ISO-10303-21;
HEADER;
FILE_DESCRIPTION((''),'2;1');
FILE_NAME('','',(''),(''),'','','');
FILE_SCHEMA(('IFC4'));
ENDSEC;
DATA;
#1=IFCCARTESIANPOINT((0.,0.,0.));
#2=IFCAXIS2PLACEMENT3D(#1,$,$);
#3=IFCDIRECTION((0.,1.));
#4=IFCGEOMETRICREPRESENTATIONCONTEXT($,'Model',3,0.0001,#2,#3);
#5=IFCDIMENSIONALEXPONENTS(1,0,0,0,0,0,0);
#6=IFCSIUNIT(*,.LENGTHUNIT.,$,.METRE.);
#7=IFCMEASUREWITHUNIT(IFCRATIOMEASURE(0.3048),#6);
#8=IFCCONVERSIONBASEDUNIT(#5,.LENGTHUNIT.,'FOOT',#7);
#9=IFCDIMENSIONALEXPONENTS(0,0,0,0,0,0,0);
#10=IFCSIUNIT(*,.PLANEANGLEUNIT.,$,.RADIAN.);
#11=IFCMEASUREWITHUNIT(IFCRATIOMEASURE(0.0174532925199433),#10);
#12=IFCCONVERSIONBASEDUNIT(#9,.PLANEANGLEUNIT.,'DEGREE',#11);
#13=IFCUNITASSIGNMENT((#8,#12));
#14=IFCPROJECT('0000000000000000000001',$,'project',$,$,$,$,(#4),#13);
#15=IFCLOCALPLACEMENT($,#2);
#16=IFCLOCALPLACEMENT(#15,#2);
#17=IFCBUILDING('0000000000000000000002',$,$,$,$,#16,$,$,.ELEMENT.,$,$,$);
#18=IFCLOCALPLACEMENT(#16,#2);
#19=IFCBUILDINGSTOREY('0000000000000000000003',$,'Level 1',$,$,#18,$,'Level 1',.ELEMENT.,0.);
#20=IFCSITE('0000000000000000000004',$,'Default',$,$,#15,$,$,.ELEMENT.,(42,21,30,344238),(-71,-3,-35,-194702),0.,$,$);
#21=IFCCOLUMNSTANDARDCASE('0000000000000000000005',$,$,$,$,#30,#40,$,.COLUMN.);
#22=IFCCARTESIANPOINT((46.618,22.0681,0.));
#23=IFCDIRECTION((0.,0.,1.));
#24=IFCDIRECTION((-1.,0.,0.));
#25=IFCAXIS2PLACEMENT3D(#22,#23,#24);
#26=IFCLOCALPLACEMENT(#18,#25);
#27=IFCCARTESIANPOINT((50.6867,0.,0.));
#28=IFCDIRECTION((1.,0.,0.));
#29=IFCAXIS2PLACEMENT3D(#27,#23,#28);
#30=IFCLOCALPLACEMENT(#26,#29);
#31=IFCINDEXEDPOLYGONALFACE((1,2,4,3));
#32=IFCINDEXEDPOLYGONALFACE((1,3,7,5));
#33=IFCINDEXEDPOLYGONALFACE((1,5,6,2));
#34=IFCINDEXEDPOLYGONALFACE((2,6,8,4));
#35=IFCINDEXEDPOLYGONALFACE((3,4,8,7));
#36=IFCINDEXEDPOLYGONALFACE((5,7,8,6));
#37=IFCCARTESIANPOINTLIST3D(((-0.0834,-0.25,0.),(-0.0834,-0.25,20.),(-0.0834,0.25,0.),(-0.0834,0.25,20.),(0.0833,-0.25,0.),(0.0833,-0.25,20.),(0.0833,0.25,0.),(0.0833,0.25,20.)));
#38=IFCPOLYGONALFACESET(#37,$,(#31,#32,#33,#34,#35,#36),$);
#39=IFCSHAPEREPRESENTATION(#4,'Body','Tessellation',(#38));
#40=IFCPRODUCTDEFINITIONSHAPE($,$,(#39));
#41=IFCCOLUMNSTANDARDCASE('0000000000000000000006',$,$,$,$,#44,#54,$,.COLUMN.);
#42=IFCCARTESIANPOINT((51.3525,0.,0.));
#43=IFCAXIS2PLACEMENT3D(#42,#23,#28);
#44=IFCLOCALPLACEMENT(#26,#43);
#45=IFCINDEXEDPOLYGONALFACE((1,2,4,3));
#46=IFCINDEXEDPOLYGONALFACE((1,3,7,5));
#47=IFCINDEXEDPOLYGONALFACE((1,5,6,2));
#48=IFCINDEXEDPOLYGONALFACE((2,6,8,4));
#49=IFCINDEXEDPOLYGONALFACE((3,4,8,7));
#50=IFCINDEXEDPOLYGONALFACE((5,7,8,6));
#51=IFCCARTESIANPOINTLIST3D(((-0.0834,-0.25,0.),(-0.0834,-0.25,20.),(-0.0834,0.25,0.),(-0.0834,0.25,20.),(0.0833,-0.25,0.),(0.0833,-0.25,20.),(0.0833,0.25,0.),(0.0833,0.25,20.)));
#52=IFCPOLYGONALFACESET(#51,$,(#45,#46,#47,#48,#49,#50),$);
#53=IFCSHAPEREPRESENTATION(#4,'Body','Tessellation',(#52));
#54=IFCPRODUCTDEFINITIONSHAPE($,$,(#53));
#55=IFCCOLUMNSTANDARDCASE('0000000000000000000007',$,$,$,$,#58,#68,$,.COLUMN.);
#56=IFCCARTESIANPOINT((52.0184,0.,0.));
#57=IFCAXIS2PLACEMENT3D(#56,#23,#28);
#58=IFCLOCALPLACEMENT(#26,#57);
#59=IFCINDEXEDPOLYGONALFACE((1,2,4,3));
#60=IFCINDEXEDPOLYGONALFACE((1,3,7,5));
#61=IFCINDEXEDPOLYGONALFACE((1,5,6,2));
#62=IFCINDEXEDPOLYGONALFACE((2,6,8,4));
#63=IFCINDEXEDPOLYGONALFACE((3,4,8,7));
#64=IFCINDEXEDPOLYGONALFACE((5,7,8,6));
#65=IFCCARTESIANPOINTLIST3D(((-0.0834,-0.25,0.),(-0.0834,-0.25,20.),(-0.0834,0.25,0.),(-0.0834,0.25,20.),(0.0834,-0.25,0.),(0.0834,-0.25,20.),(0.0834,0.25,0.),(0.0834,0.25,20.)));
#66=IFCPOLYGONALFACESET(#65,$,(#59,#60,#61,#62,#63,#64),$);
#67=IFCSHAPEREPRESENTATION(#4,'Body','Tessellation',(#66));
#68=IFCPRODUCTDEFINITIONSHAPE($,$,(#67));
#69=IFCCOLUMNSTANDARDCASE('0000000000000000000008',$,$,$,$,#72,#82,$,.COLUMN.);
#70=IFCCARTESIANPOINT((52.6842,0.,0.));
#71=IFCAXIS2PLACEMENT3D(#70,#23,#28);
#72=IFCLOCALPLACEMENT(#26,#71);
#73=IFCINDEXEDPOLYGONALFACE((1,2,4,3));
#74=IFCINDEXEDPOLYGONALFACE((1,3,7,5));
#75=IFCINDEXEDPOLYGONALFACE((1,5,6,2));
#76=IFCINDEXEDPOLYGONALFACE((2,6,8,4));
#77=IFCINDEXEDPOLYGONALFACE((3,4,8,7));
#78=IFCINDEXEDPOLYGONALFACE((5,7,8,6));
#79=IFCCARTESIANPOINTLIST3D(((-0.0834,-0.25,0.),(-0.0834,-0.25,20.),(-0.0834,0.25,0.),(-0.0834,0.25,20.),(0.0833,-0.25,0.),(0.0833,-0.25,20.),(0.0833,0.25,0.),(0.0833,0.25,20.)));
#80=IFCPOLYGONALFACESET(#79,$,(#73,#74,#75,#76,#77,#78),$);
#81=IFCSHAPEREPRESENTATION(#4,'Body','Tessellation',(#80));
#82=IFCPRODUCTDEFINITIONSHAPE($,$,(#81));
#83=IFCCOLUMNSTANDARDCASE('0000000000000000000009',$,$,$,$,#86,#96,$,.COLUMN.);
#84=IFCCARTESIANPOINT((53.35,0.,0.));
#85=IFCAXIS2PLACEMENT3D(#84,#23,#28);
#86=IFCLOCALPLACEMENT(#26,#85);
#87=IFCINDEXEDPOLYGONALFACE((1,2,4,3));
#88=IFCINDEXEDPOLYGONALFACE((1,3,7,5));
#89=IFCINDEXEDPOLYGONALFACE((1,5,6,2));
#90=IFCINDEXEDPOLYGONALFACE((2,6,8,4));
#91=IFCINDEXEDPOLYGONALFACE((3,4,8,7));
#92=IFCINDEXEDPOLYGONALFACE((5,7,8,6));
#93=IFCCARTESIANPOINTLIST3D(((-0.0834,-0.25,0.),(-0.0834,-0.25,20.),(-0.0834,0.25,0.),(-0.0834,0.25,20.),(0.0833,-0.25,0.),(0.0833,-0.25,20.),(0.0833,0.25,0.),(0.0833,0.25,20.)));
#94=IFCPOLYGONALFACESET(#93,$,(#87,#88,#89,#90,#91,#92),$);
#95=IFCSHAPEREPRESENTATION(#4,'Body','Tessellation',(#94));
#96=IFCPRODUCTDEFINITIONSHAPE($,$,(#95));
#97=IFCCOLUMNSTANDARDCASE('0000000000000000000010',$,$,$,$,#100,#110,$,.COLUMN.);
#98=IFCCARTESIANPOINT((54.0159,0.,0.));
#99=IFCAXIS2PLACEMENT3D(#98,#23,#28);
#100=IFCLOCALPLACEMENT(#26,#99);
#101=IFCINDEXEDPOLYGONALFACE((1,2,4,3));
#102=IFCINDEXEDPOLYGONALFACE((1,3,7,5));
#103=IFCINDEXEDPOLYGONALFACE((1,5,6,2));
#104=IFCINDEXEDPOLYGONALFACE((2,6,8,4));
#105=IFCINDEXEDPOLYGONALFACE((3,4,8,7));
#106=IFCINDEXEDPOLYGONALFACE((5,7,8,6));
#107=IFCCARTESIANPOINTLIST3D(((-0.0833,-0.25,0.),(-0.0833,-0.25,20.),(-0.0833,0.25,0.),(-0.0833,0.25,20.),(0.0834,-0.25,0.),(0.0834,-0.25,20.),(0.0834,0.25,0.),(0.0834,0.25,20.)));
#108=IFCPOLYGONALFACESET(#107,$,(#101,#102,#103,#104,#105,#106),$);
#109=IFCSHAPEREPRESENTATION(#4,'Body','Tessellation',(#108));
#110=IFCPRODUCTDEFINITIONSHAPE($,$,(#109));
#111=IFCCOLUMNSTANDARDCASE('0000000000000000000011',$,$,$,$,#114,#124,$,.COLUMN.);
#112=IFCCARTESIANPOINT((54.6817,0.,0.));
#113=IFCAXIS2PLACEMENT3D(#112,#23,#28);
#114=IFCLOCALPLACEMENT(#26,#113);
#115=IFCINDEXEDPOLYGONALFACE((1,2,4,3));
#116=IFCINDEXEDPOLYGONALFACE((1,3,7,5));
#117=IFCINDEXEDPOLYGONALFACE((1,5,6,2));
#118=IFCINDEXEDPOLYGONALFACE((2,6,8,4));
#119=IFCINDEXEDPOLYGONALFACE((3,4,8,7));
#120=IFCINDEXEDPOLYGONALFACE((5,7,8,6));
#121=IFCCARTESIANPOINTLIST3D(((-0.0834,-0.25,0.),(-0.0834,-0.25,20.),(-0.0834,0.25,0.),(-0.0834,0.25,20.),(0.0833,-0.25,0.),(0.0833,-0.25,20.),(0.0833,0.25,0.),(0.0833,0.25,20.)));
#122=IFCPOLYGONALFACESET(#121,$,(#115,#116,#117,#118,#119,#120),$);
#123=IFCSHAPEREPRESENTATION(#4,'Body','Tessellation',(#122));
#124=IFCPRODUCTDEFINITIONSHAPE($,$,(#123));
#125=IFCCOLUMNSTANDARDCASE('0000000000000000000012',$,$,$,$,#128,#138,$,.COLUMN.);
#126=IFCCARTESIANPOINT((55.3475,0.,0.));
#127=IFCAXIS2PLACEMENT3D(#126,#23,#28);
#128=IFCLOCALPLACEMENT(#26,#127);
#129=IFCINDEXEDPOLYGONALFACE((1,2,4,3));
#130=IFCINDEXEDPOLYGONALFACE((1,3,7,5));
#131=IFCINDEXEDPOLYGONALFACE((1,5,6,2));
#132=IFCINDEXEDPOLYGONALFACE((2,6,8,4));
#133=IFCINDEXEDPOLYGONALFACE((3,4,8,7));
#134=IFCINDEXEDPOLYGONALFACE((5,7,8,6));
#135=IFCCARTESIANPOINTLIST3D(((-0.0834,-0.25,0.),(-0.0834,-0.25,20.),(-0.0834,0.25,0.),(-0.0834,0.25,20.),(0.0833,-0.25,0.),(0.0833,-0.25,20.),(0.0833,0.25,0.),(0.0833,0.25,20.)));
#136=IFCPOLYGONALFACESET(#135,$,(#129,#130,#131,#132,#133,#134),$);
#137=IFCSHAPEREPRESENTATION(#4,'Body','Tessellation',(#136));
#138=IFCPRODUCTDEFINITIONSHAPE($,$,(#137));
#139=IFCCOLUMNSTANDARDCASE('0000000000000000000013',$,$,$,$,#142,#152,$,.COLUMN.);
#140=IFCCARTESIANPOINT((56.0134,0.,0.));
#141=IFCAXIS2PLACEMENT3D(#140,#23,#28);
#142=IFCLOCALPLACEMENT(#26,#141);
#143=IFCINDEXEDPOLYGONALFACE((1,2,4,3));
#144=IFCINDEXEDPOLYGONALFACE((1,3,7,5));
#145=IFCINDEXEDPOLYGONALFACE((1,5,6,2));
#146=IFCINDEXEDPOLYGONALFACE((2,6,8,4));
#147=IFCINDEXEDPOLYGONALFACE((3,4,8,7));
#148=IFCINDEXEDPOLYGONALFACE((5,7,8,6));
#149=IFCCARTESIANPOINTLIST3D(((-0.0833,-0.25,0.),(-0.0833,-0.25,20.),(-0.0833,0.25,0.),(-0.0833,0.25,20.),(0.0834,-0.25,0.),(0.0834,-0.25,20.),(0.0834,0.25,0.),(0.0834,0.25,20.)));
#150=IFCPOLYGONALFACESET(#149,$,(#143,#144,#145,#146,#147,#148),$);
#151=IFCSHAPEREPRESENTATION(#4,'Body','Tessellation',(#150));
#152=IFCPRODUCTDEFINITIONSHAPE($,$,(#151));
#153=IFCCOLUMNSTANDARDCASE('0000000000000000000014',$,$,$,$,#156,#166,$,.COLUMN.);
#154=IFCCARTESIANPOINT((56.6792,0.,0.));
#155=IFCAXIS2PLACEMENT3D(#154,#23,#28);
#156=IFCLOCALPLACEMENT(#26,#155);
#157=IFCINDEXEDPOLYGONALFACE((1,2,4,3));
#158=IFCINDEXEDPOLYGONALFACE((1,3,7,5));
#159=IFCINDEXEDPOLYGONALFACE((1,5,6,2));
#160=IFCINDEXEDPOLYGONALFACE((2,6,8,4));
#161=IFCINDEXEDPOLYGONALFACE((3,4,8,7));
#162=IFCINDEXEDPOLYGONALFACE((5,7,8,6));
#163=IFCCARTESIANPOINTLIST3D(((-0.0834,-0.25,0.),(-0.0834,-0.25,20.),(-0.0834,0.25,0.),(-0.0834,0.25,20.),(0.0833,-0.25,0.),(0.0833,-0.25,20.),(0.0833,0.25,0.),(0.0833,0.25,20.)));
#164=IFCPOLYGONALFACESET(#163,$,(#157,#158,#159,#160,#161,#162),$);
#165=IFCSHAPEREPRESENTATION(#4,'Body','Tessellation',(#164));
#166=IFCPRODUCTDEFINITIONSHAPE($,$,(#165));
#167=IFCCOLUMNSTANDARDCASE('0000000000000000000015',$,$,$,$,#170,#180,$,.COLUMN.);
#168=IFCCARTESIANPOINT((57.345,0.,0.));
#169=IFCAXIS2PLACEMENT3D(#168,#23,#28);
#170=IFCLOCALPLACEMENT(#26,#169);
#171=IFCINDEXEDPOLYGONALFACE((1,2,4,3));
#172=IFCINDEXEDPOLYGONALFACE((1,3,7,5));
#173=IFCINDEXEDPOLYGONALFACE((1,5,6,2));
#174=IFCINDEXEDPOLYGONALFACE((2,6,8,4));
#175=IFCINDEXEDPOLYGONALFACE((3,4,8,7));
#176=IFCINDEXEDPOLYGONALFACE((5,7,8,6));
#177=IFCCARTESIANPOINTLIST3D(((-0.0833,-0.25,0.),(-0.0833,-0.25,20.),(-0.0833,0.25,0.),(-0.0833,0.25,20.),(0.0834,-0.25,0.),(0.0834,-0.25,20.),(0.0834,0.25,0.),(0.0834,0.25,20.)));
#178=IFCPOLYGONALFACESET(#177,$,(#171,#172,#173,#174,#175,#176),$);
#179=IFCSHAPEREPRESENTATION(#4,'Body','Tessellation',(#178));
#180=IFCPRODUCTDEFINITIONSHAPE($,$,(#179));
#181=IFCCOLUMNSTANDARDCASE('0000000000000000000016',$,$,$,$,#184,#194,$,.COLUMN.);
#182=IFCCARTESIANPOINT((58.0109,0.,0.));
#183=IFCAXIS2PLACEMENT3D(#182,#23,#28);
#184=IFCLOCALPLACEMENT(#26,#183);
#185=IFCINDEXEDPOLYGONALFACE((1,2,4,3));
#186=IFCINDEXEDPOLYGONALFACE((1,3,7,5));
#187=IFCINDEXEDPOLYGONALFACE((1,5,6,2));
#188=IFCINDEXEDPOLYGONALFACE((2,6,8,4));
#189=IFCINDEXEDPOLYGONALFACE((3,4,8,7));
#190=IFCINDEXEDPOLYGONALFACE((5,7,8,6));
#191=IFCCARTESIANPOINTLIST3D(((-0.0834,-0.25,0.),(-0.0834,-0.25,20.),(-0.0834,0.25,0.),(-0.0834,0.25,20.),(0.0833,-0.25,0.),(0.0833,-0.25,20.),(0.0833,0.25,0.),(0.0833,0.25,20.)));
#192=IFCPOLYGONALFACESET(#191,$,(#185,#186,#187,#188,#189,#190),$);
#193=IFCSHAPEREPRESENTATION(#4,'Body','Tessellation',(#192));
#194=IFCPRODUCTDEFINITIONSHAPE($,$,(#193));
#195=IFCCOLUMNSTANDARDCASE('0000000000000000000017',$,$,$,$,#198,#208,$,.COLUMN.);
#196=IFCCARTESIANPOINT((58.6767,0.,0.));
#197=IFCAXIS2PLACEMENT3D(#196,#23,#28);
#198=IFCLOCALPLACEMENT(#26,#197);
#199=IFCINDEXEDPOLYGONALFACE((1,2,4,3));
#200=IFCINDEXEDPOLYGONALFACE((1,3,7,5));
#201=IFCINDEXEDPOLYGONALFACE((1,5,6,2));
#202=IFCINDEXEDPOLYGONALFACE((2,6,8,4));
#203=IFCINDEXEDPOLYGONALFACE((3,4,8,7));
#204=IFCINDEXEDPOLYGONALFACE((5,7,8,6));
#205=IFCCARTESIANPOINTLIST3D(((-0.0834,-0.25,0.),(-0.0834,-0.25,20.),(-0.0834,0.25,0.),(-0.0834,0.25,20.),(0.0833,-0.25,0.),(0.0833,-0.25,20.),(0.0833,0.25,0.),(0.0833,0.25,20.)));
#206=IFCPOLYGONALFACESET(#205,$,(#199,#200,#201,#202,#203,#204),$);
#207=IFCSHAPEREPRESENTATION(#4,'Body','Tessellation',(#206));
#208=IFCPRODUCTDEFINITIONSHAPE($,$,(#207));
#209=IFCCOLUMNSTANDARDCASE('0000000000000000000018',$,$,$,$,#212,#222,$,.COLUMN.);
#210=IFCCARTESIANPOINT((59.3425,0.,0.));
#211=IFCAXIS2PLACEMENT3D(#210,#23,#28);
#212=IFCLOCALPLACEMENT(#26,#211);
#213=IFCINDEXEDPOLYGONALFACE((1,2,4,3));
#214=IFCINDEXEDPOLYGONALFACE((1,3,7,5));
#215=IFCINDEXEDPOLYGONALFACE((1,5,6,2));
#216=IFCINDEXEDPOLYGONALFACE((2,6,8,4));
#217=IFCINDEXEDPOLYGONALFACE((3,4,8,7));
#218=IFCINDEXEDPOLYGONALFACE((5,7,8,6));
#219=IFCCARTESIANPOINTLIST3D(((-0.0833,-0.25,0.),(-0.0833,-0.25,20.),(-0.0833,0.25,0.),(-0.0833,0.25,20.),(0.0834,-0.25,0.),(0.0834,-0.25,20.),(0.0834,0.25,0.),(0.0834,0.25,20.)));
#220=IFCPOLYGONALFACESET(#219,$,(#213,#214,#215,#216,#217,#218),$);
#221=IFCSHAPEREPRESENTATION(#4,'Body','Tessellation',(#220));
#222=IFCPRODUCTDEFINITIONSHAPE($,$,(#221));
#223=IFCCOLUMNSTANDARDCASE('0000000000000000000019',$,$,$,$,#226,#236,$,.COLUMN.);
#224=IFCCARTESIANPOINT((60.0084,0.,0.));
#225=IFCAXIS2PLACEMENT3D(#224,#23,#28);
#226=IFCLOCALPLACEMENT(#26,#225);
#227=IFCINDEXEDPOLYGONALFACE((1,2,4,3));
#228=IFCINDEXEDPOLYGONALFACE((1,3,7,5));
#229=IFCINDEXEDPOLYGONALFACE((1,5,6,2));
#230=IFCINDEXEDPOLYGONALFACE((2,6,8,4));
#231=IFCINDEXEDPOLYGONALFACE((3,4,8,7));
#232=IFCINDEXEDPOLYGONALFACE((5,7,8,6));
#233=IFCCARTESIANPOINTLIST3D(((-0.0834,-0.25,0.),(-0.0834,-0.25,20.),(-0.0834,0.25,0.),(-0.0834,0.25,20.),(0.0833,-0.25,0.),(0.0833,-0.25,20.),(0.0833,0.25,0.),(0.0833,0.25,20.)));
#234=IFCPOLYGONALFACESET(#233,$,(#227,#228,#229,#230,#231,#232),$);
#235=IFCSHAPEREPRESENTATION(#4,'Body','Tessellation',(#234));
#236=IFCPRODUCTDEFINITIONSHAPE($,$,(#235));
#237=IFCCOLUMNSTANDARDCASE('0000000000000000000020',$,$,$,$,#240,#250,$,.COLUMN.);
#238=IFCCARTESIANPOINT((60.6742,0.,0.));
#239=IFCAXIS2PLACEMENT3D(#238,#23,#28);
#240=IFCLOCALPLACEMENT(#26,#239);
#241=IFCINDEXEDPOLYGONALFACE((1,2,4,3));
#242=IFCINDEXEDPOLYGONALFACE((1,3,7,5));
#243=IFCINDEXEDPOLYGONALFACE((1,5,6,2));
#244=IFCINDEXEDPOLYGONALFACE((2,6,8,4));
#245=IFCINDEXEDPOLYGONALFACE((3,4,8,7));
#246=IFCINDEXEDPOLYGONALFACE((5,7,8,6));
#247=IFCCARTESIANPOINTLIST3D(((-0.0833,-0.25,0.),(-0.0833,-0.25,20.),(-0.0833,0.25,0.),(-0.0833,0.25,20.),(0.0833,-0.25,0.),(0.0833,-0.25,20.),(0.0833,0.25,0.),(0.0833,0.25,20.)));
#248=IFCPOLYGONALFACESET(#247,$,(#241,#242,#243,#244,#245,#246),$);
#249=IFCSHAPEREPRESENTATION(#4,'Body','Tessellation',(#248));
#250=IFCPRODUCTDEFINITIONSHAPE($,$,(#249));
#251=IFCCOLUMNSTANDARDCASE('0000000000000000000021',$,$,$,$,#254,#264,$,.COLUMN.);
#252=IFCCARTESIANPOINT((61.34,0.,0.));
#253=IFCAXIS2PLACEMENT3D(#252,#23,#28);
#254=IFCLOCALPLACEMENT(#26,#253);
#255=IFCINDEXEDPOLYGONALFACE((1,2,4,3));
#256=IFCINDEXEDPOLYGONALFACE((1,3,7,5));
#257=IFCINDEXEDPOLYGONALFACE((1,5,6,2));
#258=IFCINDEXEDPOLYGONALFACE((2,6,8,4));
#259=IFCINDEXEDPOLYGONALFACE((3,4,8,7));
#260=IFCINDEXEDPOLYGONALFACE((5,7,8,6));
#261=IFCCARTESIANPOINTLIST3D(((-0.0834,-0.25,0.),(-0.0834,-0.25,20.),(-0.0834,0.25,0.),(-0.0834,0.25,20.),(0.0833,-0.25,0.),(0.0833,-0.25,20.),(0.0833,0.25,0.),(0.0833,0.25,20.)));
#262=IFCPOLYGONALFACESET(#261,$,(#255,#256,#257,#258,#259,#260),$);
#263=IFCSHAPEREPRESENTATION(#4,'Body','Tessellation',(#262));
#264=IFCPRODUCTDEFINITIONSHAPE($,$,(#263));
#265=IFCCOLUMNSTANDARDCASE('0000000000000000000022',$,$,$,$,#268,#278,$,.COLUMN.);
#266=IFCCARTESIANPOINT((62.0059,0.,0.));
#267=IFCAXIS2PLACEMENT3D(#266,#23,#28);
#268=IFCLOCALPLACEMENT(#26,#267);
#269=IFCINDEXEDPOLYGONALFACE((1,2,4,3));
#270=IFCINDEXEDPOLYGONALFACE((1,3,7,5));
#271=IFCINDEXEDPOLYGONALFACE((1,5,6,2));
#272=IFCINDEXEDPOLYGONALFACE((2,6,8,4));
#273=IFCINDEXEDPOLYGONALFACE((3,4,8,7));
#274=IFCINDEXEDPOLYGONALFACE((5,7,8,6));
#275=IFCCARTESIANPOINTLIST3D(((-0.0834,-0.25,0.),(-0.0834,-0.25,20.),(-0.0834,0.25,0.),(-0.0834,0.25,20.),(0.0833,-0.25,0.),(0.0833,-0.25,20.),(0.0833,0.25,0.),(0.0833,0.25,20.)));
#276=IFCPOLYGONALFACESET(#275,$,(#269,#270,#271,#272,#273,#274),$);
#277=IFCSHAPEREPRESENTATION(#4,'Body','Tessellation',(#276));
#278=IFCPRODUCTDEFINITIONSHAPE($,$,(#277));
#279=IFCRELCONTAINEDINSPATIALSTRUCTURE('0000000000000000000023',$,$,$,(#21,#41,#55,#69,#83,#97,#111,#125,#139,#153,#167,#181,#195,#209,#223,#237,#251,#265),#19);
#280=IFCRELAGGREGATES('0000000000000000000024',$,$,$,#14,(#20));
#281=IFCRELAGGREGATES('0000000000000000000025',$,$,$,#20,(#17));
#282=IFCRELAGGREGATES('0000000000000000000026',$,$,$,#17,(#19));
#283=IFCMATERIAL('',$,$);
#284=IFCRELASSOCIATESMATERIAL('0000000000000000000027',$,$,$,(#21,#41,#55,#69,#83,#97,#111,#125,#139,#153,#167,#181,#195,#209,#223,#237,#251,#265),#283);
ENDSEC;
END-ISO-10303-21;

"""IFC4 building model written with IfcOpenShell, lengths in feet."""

from ifc_helpers import new_model, entity, si_unit, converted_unit, direction, frame, origin, place, context, project, spatial, rectangle, extrude, material, element, save


model = new_model("IFC4")

# Units and contexts
model_context = context("Model", 3, precision=0.0001, world=origin(), true_north=direction((0.0, 1.0)))
ifc_project = project(units=[converted_unit("LENGTHUNIT", "FOOT", entity("IfcRatioMeasure", 0.3048), si_unit("LENGTHUNIT", "METRE"), dimensions=[1, 0, 0, 0, 0, 0, 0]), converted_unit("PLANEANGLEUNIT", "DEGREE", entity("IfcRatioMeasure", 0.0174532925199433), si_unit("PLANEANGLEUNIT", "RADIAN"), dimensions=[0, 0, 0, 0, 0, 0, 0])], contexts=[model_context])

# Site, building, storey
site_placement = place(None, origin())
site = spatial("IfcSite", under=ifc_project, at=site_placement, Name="Default", CompositionType="ELEMENT", RefLatitude=(42, 21, 30, 344238), RefLongitude=(-71, -3, -35, -194702), RefElevation=0.0)
building_placement = place(site_placement, origin())
building = spatial("IfcBuilding", under=site, at=building_placement, CompositionType="ELEMENT")
storey_placement = place(building_placement, origin())
storey = spatial("IfcBuildingStorey", under=building, at=storey_placement, Name="Level 1", LongName="Level 1", CompositionType="ELEMENT", Elevation=0.0)

# Columns
ifc_material_1 = material(Name="")
placement = place(storey_placement, frame((46.618, 22.0681, 0.0), z_axis=(0.0, 0.0, 1.0), x_axis=(-1.0, 0.0, 0.0)))
for number, where, z_axis, x_axis in (
    (1, (50.6867, 0.0, 0.0), (0.0, 0.0, 1.0), (1.0, 0.0, 0.0)),
    (2, (51.3525, 0.0, 0.0), (0.0, 0.0, 1.0), (1.0, 0.0, 0.0)),
    (3, (52.0184, 0.0, 0.0), (0.0, 0.0, 1.0), (1.0, 0.0, 0.0)),
    (4, (52.6842, 0.0, 0.0), (0.0, 0.0, 1.0), (1.0, 0.0, 0.0)),
    (5, (53.35, 0.0, 0.0), (0.0, 0.0, 1.0), (1.0, 0.0, 0.0)),
    (6, (54.0159, 0.0, 0.0), (0.0, 0.0, 1.0), (1.0, 0.0, 0.0)),
    (7, (54.6817, 0.0, 0.0), (0.0, 0.0, 1.0), (1.0, 0.0, 0.0)),
    (8, (55.3475, 0.0, 0.0), (0.0, 0.0, 1.0), (1.0, 0.0, 0.0)),
    (9, (56.0134, 0.0, 0.0), (0.0, 0.0, 1.0), (1.0, 0.0, 0.0)),
    (10, (56.6792, 0.0, 0.0), (0.0, 0.0, 1.0), (1.0, 0.0, 0.0)),
    (11, (57.345, 0.0, 0.0), (0.0, 0.0, 1.0), (1.0, 0.0, 0.0)),
    (12, (58.0109, 0.0, 0.0), (0.0, 0.0, 1.0), (1.0, 0.0, 0.0)),
    (13, (58.6767, 0.0, 0.0), (0.0, 0.0, 1.0), (1.0, 0.0, 0.0)),
    (14, (59.3425, 0.0, 0.0), (0.0, 0.0, 1.0), (1.0, 0.0, 0.0)),
    (15, (60.0084, 0.0, 0.0), (0.0, 0.0, 1.0), (1.0, 0.0, 0.0)),
    (16, (60.6742, 0.0, 0.0), (0.0, 0.0, 1.0), (1.0, 0.0, 0.0)),
    (17, (61.34, 0.0, 0.0), (0.0, 0.0, 1.0), (1.0, 0.0, 0.0)),
    (18, (62.0059, 0.0, 0.0), (0.0, 0.0, 1.0), (1.0, 0.0, 0.0)),
):
    element("IfcColumnStandardCase", number, at=place(placement, frame(where, z_axis=z_axis, x_axis=x_axis)), inside=storey, material=ifc_material_1, PredefinedType="COLUMN", context=model_context, shape_type="SweptSolid", body=[
        extrude(rectangle(XDim=0.1667, YDim=0.5), origin(), (0.0, 0.0, 1.0), 20.0),
    ])

save(model, "model.ifc")
